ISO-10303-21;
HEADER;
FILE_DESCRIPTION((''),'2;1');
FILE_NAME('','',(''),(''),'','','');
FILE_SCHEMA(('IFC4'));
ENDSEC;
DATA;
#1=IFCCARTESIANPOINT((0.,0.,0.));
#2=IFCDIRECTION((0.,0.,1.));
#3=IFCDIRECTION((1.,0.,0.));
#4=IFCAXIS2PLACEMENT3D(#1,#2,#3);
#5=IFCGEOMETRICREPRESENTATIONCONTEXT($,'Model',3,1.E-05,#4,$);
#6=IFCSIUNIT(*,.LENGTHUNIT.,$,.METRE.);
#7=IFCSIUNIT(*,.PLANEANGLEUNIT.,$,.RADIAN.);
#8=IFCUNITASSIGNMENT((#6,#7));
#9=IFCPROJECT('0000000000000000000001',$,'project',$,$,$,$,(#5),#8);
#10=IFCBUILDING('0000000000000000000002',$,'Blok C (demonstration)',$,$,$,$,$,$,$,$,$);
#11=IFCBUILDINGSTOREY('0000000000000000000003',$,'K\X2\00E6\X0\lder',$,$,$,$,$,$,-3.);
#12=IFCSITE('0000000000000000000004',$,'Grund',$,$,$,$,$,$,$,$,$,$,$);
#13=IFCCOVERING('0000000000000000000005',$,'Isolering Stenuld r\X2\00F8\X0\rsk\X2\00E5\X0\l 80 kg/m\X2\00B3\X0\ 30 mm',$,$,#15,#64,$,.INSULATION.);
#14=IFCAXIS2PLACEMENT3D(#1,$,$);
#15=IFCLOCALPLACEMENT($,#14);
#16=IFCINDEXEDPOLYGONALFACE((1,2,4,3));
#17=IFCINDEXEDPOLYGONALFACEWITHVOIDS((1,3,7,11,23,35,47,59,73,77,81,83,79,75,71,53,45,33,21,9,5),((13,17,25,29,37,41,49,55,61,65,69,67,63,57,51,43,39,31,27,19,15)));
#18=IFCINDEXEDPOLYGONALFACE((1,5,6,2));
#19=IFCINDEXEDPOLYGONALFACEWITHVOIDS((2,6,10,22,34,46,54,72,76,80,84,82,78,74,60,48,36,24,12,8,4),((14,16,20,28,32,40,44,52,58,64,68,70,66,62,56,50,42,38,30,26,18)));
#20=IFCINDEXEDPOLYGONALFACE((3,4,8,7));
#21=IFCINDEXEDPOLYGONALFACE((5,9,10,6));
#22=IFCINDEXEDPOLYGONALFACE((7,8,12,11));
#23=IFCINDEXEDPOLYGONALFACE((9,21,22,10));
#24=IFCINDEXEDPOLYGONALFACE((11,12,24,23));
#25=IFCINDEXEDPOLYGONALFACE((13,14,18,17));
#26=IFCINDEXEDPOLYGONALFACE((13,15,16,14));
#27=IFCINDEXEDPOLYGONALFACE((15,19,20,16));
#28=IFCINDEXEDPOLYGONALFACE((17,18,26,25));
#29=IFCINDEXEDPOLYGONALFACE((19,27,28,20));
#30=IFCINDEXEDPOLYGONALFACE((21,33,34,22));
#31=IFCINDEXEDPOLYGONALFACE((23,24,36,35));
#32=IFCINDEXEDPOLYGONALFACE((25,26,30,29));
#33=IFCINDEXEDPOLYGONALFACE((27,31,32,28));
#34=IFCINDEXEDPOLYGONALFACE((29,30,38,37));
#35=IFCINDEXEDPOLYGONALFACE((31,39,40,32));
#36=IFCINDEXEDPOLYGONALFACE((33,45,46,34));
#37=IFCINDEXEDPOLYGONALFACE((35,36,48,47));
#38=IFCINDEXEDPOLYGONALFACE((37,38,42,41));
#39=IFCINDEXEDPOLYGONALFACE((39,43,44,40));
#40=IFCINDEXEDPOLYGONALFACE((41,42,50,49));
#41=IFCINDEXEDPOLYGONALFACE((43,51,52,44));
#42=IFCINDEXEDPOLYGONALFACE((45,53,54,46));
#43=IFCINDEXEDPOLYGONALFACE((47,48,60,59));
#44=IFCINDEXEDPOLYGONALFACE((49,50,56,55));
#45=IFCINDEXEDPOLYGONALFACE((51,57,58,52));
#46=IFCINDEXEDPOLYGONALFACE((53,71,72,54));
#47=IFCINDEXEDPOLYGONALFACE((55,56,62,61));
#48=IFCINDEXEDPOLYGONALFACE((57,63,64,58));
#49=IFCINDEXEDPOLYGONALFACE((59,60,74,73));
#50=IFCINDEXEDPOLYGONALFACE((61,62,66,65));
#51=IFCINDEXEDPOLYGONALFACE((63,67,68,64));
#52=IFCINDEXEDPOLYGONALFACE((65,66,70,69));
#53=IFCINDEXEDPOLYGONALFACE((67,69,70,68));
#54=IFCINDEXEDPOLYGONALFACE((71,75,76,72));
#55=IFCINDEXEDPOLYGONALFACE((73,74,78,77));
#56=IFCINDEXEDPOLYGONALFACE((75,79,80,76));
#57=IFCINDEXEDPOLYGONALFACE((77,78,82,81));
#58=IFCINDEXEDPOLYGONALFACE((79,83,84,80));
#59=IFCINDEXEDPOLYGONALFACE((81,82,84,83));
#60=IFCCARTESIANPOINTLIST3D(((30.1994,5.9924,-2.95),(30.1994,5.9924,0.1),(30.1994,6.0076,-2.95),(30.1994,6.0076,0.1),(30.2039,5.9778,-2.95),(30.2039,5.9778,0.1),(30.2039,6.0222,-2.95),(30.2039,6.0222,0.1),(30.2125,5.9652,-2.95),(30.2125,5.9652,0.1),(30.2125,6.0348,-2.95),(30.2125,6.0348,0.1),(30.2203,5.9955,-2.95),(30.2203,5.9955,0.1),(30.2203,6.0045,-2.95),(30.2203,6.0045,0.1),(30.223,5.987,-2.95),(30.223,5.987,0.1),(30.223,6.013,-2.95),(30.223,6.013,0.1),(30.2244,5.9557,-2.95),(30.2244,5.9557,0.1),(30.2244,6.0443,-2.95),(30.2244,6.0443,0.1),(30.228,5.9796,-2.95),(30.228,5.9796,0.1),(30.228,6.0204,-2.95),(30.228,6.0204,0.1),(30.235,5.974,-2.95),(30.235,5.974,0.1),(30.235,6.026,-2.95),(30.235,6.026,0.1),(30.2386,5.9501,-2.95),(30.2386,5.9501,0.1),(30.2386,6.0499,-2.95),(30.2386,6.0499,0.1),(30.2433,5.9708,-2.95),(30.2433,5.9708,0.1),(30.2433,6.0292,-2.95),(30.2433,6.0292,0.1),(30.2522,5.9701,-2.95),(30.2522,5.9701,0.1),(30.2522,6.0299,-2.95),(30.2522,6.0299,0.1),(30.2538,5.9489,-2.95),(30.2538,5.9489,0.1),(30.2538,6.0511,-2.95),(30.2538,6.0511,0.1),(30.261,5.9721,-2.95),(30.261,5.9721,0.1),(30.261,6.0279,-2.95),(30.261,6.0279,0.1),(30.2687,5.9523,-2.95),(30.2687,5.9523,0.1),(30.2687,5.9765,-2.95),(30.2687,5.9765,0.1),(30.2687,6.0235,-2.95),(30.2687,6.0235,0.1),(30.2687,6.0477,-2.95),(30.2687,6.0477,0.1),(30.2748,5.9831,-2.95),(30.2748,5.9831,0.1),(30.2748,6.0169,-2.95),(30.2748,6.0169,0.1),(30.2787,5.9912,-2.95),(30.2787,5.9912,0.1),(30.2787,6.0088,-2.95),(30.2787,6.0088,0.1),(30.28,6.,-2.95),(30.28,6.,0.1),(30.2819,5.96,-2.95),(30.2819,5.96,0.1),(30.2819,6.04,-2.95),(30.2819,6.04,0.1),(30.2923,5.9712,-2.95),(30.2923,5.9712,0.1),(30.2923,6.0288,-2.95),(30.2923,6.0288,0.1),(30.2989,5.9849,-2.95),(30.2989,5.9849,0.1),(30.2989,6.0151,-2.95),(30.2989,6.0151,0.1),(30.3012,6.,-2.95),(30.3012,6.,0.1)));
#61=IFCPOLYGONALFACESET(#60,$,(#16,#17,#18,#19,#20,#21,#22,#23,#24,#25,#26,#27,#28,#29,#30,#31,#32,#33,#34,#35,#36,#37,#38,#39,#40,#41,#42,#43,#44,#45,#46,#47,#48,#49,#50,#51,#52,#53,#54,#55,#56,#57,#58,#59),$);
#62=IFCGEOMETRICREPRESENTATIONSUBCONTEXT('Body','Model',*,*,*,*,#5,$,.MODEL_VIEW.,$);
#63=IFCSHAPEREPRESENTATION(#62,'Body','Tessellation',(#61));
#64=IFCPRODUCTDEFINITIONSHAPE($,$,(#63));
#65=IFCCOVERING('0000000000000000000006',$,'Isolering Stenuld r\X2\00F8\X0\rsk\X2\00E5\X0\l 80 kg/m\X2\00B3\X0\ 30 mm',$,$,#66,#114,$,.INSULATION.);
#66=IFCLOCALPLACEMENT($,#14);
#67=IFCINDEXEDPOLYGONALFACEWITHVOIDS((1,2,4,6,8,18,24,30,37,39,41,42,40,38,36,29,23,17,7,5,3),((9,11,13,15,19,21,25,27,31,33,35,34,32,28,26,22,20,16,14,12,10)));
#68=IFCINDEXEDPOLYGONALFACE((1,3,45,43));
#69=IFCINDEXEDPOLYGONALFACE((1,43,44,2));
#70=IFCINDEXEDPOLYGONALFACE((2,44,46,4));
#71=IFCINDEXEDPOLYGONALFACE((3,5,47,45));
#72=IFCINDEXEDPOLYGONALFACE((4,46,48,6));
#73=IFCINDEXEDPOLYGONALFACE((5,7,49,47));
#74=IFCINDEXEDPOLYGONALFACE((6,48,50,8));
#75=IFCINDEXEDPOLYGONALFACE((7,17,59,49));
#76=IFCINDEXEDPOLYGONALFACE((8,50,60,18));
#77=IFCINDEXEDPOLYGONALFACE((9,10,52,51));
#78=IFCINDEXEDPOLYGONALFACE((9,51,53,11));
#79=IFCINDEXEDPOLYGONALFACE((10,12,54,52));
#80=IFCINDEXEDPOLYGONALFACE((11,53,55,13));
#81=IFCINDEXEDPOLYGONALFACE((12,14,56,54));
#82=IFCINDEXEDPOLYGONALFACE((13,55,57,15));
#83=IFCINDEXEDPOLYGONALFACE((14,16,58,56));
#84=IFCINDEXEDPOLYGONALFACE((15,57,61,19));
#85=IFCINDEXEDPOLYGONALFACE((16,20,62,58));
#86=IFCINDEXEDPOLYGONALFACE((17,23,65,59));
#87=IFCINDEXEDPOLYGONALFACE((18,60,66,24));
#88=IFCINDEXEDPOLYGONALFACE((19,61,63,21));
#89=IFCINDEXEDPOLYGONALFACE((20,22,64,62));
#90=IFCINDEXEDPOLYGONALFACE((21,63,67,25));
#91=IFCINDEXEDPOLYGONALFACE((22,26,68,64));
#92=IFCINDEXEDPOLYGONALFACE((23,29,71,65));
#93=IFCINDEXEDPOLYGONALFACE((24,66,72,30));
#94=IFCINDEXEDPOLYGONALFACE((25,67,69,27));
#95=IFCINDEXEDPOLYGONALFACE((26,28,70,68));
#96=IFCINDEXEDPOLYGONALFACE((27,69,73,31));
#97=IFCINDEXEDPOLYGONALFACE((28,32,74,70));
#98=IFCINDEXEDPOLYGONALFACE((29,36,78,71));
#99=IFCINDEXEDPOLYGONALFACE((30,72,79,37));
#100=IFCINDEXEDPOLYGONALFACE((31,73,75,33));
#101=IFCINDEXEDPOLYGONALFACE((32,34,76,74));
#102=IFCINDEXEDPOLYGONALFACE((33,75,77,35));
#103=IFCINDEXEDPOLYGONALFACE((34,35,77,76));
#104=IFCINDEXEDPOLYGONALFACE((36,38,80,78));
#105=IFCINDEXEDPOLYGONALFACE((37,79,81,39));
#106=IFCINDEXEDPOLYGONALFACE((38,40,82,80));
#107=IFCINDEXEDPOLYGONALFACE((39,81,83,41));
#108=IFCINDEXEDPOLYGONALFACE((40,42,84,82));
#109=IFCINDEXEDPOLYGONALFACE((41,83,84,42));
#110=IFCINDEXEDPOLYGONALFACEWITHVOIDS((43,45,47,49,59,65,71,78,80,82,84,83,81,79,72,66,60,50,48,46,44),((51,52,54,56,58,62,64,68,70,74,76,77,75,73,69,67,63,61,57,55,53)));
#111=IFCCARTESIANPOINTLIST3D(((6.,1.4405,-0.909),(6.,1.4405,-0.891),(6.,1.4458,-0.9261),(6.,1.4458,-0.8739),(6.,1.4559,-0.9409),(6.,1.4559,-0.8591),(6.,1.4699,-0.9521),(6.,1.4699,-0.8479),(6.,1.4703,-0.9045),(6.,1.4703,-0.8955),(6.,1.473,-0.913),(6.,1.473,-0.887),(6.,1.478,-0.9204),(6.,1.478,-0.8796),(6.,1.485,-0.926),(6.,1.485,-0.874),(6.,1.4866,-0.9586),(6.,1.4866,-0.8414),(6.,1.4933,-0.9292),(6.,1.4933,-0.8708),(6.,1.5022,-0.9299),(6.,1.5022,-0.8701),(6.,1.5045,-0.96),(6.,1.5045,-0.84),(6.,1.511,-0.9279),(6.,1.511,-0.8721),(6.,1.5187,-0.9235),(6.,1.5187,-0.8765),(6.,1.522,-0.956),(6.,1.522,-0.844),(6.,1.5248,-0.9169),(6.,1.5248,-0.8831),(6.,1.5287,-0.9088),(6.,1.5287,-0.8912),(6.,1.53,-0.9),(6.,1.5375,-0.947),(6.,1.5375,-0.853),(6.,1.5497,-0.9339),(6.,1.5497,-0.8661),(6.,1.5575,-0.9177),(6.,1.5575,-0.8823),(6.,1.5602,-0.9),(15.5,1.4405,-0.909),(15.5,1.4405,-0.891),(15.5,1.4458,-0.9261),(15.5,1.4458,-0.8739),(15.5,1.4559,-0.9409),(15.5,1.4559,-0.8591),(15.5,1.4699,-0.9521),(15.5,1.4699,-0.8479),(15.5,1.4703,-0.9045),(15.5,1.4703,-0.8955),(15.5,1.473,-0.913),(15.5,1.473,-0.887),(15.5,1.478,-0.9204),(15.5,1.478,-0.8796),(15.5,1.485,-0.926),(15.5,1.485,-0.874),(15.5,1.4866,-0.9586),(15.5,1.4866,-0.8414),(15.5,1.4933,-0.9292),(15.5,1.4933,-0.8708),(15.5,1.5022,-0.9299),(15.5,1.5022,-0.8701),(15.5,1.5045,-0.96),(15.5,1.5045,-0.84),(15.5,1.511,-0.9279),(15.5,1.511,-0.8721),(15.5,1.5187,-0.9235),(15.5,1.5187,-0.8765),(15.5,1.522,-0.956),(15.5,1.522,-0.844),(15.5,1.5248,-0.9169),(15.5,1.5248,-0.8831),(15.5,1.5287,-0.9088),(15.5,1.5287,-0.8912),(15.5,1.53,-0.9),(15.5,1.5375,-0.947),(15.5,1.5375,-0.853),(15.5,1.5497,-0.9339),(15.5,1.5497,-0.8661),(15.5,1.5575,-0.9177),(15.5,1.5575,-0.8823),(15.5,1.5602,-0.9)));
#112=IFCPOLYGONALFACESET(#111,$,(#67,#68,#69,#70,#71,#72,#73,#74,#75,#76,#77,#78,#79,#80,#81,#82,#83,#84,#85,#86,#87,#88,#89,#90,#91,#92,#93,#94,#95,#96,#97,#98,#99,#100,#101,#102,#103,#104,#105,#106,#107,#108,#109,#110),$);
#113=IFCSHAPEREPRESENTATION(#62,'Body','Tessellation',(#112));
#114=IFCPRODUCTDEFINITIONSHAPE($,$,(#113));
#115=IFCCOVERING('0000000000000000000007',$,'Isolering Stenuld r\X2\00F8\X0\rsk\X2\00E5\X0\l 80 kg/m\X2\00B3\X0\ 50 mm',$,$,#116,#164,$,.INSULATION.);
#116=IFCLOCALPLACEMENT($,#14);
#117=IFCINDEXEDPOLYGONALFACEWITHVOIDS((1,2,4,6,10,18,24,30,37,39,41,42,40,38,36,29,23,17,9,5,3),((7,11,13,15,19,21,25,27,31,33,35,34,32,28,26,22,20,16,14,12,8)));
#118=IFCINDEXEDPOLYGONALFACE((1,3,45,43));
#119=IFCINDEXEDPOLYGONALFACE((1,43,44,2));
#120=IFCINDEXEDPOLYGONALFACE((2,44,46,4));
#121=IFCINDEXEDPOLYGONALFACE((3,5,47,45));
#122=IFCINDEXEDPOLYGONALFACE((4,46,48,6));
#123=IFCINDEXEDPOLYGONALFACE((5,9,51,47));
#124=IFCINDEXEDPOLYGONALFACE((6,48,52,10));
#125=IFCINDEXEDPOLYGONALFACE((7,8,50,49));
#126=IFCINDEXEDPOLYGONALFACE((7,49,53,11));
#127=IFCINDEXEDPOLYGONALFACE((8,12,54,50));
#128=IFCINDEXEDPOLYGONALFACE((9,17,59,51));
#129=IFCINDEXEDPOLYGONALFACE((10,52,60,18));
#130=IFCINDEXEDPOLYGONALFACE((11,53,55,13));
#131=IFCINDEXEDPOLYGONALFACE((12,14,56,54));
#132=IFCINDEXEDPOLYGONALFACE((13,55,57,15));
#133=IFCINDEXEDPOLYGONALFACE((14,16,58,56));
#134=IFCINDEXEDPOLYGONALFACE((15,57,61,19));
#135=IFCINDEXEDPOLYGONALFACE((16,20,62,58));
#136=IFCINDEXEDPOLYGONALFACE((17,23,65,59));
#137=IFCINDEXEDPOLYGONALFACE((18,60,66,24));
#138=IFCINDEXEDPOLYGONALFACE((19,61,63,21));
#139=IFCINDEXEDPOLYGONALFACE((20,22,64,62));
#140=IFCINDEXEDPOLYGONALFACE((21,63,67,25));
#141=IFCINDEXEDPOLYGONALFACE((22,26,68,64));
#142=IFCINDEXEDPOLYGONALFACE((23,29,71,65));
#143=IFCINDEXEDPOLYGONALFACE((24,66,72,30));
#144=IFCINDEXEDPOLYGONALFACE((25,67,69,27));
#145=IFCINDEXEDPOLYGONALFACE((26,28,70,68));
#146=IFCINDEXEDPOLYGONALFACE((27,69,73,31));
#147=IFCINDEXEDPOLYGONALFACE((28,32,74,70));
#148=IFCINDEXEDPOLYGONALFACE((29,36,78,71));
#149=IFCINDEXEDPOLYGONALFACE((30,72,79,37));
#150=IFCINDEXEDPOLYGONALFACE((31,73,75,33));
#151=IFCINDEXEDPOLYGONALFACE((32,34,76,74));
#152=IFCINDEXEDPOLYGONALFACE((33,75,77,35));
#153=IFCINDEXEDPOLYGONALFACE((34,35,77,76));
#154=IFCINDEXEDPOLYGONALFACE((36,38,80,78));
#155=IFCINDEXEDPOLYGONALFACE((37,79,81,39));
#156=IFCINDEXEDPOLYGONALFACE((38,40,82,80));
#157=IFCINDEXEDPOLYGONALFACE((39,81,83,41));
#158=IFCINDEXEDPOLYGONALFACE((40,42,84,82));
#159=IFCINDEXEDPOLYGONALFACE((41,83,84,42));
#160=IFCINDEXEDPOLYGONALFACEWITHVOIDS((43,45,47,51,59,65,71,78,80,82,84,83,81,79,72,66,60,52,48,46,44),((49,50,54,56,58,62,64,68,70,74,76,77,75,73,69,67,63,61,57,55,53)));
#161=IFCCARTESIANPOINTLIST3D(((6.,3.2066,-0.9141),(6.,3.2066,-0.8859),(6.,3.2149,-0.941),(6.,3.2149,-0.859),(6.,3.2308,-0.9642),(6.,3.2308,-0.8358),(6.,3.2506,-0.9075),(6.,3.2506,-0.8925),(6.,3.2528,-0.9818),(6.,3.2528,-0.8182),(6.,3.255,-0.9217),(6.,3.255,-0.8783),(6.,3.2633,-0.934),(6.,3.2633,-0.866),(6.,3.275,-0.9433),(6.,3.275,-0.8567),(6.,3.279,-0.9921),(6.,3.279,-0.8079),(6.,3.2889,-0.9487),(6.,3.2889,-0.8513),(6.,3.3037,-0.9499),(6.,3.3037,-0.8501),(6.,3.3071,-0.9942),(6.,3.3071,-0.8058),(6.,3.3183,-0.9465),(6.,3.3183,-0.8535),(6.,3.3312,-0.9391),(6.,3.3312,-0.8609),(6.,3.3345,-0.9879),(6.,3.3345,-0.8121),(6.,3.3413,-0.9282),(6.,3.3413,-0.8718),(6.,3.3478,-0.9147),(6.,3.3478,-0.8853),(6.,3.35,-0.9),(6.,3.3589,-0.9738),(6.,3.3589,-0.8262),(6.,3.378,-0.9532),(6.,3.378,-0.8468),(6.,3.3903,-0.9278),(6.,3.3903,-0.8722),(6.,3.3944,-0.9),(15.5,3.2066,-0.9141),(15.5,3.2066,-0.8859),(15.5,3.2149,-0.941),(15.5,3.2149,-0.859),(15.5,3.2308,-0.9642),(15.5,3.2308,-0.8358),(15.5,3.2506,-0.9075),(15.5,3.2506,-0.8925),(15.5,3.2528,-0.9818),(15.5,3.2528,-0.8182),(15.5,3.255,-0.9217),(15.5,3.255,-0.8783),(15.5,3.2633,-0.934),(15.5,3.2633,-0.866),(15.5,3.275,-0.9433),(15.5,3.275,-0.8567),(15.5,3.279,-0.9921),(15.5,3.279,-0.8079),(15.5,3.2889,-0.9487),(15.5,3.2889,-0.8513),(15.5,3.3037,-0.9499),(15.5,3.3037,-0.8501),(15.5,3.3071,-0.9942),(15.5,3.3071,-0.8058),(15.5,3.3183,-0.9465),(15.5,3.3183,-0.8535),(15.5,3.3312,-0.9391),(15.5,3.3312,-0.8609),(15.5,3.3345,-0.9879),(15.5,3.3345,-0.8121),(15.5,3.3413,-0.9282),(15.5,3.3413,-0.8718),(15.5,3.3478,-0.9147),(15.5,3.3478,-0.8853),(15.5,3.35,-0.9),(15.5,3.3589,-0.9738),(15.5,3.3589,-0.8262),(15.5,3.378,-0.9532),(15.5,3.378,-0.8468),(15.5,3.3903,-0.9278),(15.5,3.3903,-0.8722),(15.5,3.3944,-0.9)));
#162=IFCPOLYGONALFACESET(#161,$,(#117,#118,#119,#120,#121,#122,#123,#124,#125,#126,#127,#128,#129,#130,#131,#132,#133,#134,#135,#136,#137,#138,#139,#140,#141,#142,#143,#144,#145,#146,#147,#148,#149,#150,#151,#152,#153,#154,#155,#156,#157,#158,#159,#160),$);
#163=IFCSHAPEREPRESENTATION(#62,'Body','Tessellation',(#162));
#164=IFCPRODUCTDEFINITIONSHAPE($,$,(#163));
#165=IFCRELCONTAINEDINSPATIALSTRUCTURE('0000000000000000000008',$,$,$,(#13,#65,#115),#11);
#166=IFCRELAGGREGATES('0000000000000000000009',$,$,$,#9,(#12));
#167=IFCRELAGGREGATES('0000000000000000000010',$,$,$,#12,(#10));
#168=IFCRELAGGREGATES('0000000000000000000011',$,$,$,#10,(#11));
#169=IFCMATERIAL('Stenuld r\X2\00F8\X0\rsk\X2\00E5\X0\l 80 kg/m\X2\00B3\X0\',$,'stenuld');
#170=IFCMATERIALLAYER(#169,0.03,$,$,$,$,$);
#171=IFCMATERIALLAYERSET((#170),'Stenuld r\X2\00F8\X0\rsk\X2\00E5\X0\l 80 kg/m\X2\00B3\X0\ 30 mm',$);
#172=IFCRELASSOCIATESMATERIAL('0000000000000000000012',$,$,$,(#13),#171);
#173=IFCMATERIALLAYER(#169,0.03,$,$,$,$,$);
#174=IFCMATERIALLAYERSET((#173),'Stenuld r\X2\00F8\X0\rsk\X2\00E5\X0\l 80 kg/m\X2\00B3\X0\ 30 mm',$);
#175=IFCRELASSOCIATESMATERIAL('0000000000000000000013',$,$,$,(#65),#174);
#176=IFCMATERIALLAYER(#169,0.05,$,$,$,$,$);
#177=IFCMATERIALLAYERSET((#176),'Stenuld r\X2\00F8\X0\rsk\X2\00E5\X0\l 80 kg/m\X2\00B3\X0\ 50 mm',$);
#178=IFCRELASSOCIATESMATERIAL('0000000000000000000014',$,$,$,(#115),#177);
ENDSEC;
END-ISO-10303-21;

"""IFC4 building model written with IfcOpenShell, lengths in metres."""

from ifc_helpers import new_model, si_unit, frame, origin_with_axes, place, context, subcontext, project, spatial, hollow_circle, extrude, material, layer, layer_set, element, save


model = new_model("IFC4")

# Units and contexts
model_context = context("Model", 3, precision=1e-05, world=origin_with_axes())
body_context = subcontext(model_context, "Body", "Model", "MODEL_VIEW")
ifc_project = project(units=[si_unit("LENGTHUNIT", "METRE"), si_unit("PLANEANGLEUNIT", "RADIAN")], contexts=[model_context])

# Site, building, storey
site = spatial("IfcSite", under=ifc_project, Name="Grund")
building = spatial("IfcBuilding", under=site, Name="Blok C (demonstration)")
storey = spatial("IfcBuildingStorey", under=building, Name="Kælder", Elevation=-3.0)

# Coverings
ifc_material_1 = material(Name="Stenuld rørskål 80 kg/m³", Category="stenuld")
ifc_layer_1 = layer(ifc_material_1, 0.03)
ifc_layer_set_1 = layer_set([ifc_layer_1], Name="Stenuld rørskål 80 kg/m³ 30 mm")
covering_1_placement = place(None, origin_with_axes())
element("IfcCovering", 1, at=covering_1_placement, inside=storey, material=ifc_layer_set_1, Name="Isolering Stenuld rørskål 80 kg/m³ 30 mm", PredefinedType="INSULATION", context=body_context, shape_type="SweptSolid", body=[
    extrude(hollow_circle(Radius=0.0512, WallThickness=0.0212), frame((30.25, 6.0, -2.95), z_axis=(0.0, 0.0, 1.0), x_axis=(1.0, 0.0, 0.0)), (0.0, 0.0, 1.0), 3.05),
])
ifc_layer_2 = layer(ifc_material_1, 0.03)
ifc_layer_set_2 = layer_set([ifc_layer_2], Name="Stenuld rørskål 80 kg/m³ 30 mm")
covering_2_placement = place(None, origin_with_axes())
element("IfcCovering", 2, at=covering_2_placement, inside=storey, material=ifc_layer_set_2, Name="Isolering Stenuld rørskål 80 kg/m³ 30 mm", PredefinedType="INSULATION", context=body_context, shape_type="SweptSolid", body=[
    extrude(hollow_circle(Radius=0.0601, WallThickness=0.0301), frame((6.0, 1.5, -0.9), z_axis=(1.0, 0.0, 0.0), x_axis=(0.0, 1.0, 0.0)), (0.0, 0.0, 1.0), 9.5),
])
ifc_layer_3 = layer(ifc_material_1, 0.05)
ifc_layer_set_3 = layer_set([ifc_layer_3], Name="Stenuld rørskål 80 kg/m³ 50 mm")
covering_3_placement = place(None, origin_with_axes())
element("IfcCovering", 3, at=covering_3_placement, inside=storey, material=ifc_layer_set_3, Name="Isolering Stenuld rørskål 80 kg/m³ 50 mm", PredefinedType="INSULATION", context=body_context, shape_type="SweptSolid", body=[
    extrude(hollow_circle(Radius=0.0945, WallThickness=0.0445), frame((6.0, 3.3, -0.9), z_axis=(1.0, 0.0, 0.0), x_axis=(0.0, 1.0, 0.0)), (0.0, 0.0, 1.0), 9.5),
])

save(model, "model.ifc")
